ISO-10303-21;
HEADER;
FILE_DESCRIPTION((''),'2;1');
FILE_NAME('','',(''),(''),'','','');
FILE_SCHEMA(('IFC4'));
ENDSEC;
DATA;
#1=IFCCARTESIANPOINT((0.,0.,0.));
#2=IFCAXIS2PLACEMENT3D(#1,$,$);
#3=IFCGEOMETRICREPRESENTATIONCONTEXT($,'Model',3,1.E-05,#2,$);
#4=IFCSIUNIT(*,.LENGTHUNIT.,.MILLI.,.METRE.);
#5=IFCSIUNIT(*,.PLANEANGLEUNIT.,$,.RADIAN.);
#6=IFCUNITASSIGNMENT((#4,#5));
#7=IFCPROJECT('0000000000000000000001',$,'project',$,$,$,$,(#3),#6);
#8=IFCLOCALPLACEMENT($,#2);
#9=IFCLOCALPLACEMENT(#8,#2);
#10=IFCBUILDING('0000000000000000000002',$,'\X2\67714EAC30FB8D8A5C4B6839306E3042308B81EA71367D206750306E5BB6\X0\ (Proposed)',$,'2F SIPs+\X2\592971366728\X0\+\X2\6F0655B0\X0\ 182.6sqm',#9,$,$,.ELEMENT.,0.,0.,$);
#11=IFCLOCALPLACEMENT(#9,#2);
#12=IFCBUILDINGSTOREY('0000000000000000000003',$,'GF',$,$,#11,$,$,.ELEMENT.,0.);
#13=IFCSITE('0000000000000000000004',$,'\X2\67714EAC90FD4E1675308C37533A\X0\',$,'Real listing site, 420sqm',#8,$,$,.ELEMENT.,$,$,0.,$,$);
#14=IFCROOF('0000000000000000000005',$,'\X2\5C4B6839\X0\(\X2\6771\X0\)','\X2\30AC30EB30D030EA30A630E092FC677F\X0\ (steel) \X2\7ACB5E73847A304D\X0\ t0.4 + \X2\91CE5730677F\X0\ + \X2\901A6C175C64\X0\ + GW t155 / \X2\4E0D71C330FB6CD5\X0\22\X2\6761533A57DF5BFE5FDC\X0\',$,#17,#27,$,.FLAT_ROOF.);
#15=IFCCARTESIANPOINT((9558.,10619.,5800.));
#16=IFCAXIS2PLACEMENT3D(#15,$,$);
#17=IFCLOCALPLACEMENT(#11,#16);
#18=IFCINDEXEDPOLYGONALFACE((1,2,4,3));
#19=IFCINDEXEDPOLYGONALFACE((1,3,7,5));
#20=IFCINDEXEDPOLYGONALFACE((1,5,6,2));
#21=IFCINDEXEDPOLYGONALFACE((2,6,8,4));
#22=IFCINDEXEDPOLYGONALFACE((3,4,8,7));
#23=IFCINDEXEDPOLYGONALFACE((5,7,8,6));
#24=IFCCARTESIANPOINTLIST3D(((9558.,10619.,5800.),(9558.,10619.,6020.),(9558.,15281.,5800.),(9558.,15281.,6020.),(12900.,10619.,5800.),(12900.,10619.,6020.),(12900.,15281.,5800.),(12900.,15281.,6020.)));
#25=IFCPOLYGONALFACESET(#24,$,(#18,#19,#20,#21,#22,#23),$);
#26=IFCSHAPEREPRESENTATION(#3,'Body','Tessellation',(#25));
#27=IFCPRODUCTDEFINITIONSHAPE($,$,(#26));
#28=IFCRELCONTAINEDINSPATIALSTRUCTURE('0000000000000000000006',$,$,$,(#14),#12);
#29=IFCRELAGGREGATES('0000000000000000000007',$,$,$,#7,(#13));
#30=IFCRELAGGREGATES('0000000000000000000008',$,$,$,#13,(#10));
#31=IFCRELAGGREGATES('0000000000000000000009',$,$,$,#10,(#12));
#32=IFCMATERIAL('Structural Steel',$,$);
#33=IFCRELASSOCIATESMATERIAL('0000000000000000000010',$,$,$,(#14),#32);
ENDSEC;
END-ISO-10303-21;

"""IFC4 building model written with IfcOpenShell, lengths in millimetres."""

from ifc_helpers import new_model, si_unit, frame, frame_2d, origin, place, context, project, spatial, rectangle, extrude, material, element, save


model = new_model("IFC4")

# Units and contexts
model_context = context("Model", 3, precision=1e-05, world=origin())
ifc_project = project(units=[si_unit("LENGTHUNIT", "METRE", prefix="MILLI"), si_unit("PLANEANGLEUNIT", "RADIAN")], contexts=[model_context])

# Site, building, storey
site_placement = place(None, origin())
site = spatial("IfcSite", under=ifc_project, at=site_placement, Name="東京都世田谷区", ObjectType="Real listing site, 420sqm", CompositionType="ELEMENT", RefElevation=0.0)
building_placement = place(site_placement, origin())
building = spatial("IfcBuilding", under=site, at=building_placement, Name="東京・越屋根のある自然素材の家 (Proposed)", ObjectType="2F SIPs+天然木+漆喰 182.6sqm", CompositionType="ELEMENT", ElevationOfRefHeight=0.0, ElevationOfTerrain=0.0)
storey_placement = place(building_placement, origin())
storey = spatial("IfcBuildingStorey", under=building, at=storey_placement, Name="GF", CompositionType="ELEMENT", Elevation=0.0)

# Roof
ifc_material_1 = material(Name="Structural Steel")
for number, where, name in (
    (1, (9558.0, 10619.0, 5800.0), "屋根(東)"),
):
    element("IfcRoof", number, at=place(storey_placement, frame(where)), inside=storey, material=ifc_material_1, Name=name, Description="ガルバリウム鋼板 (steel) 立平葺き t0.4 + 野地板 + 通気層 + GW t155 / 不燃・法22条区域対応", PredefinedType="FLAT_ROOF", context=model_context, shape_type="SweptSolid", body=[
        extrude(rectangle(XDim=3342.0, YDim=4662.0, at=frame_2d((1671.0, 2331.0))), frame((9558.0, 10619.0, 5800.0)), (0.0, 0.0, 1.0), 220.0),
    ])

save(model, "model.ifc")
